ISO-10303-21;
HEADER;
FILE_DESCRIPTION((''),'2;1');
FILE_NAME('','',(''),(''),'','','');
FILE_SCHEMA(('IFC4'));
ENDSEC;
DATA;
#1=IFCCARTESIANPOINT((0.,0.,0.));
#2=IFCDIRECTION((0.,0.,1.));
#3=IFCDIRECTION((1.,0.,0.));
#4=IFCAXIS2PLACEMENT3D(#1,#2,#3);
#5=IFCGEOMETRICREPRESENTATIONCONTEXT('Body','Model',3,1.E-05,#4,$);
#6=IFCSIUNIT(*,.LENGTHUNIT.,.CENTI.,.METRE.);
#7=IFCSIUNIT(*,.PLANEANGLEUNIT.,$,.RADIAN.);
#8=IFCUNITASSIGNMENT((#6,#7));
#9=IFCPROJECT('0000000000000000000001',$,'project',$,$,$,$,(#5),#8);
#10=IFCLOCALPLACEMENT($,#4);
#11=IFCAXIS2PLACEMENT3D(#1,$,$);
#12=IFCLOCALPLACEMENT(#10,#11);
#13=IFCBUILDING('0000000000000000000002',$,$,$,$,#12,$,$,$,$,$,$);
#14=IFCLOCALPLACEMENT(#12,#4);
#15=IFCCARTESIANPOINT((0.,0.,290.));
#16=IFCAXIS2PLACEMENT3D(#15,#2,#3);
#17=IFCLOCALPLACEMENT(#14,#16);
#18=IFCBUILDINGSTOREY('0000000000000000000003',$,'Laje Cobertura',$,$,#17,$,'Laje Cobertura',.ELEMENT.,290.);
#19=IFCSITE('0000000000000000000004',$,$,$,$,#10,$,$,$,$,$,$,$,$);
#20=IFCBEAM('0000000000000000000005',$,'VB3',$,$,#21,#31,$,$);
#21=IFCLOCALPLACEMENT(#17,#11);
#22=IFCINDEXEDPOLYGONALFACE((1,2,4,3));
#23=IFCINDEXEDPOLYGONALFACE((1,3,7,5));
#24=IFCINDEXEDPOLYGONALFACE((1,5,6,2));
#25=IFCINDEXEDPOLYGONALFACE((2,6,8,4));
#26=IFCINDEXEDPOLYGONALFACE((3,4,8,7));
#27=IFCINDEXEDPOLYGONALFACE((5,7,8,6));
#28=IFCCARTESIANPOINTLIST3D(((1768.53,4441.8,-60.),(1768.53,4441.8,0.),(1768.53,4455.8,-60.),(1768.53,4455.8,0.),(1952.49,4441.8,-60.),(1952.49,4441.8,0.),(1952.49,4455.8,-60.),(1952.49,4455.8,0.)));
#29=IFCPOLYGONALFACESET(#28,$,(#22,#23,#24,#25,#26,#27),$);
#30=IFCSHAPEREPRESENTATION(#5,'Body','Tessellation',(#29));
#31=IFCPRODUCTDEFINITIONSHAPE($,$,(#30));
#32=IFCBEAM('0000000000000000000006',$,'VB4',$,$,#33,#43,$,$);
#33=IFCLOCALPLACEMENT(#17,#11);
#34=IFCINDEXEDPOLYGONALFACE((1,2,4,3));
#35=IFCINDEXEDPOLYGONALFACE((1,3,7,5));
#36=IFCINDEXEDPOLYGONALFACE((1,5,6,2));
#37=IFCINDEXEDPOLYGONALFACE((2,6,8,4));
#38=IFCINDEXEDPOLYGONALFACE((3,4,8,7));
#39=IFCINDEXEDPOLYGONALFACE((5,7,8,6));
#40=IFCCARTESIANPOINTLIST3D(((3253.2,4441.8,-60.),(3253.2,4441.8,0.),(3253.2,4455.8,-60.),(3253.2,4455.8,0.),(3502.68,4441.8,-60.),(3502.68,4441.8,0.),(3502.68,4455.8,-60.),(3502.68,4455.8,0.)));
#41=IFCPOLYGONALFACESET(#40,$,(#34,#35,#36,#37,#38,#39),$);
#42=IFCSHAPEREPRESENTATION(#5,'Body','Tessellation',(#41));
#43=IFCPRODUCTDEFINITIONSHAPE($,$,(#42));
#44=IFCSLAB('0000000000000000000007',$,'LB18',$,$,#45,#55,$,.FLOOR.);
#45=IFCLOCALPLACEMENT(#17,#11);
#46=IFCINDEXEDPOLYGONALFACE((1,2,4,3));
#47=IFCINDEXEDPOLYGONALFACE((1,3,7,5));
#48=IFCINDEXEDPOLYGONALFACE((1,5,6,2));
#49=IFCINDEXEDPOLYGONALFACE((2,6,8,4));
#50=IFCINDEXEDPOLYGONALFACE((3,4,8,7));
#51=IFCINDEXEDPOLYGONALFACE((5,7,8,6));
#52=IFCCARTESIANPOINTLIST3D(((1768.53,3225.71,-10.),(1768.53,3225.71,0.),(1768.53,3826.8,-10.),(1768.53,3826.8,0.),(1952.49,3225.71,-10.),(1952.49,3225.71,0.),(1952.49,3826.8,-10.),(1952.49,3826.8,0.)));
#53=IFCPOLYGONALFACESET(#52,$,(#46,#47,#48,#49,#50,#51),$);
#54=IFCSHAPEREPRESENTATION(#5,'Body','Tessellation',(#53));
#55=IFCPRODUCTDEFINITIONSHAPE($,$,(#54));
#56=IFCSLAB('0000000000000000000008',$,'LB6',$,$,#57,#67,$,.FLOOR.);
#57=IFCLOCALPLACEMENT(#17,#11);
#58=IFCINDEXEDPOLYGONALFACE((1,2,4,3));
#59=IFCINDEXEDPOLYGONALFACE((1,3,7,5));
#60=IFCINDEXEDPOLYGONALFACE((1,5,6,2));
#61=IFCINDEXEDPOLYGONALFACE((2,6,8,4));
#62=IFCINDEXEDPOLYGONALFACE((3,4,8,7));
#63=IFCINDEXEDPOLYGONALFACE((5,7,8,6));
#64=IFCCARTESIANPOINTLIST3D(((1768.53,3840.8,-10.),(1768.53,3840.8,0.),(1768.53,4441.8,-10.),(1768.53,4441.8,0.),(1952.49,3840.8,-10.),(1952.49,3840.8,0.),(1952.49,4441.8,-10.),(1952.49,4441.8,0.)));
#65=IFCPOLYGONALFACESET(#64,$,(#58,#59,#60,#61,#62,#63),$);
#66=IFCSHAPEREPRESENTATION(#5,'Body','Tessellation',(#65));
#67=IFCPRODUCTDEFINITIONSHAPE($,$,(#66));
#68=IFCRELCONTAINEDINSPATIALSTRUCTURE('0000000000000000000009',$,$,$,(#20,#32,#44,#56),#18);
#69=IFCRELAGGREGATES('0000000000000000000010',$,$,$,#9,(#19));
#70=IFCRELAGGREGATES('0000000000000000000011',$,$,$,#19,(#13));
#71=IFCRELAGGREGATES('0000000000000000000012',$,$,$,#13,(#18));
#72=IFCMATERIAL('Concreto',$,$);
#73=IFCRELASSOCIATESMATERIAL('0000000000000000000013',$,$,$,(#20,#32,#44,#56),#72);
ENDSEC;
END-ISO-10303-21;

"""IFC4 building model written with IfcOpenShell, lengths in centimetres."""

from ifc_helpers import new_model, si_unit, frame, origin, origin_with_axes, origin_2d_with_axis, place, context, project, spatial, polyline, rectangle, outline, extrude, material, element, save


model = new_model("IFC4")

# Units and contexts
model_context = context("Model", 3, precision=1e-05, world=origin_with_axes(), identifier="Body")
ifc_project = project(units=[si_unit("LENGTHUNIT", "METRE", prefix="CENTI"), si_unit("PLANEANGLEUNIT", "RADIAN")], contexts=[model_context])

# Site, building, storey
site_placement = place(None, origin_with_axes())
site = spatial("IfcSite", under=ifc_project, at=site_placement)
building_placement = place(site_placement, origin())
building = spatial("IfcBuilding", under=site, at=building_placement)
placement = place(building_placement, origin_with_axes())
storey_placement = place(placement, frame((0.0, 0.0, 290.0), z_axis=(0.0, 0.0, 1.0), x_axis=(1.0, 0.0, 0.0)))
storey = spatial("IfcBuildingStorey", under=building, at=storey_placement, Name="Laje Cobertura", LongName="Laje Cobertura", CompositionType="ELEMENT", Elevation=290.0)

# Shared definitions
ifc_material = material(Name="Concreto")

# Beams
beam_1_placement = place(storey_placement, frame((1860.51, 4448.8, 0.0), z_axis=(0.0, 0.0, 1.0), x_axis=(1.0, 0.0, 0.0)))
element("IfcBeam", 1, at=beam_1_placement, inside=storey, material=ifc_material, Name="VB3", context=model_context, shape_type="SolidModel", body=[
    extrude(rectangle(XDim=14.0, YDim=60.0, at=origin_2d_with_axis()), frame((-91.98, 0.0, -30.0), z_axis=(1.0, 0.0, 0.0), x_axis=(0.0, 1.0, 0.0)), (0.0, 0.0, 1.0), 183.96),
])
beam_2_placement = place(storey_placement, frame((3377.94, 4448.8, 0.0), z_axis=(0.0, 0.0, 1.0), x_axis=(1.0, 0.0, 0.0)))
element("IfcBeam", 2, at=beam_2_placement, inside=storey, material=ifc_material, Name="VB4", context=model_context, shape_type="SolidModel", body=[
    extrude(rectangle(XDim=14.0, YDim=60.0, at=origin_2d_with_axis()), frame((-124.74, 0.0, -30.0), z_axis=(1.0, 0.0, 0.0), x_axis=(0.0, 1.0, 0.0)), (0.0, 0.0, 1.0), 249.48),
])

# Slabs
slab_1_placement = place(storey_placement, frame((1860.51, 3526.26, 0.0), z_axis=(0.0, 0.0, 1.0), x_axis=(1.0, 0.0, 0.0)))
element("IfcSlab", 3, at=slab_1_placement, inside=storey, material=ifc_material, Name="LB18", PredefinedType="FLOOR", context=model_context, shape_type="SolidModel", body=[
    extrude(outline(polyline([(91.98, -300.55), (91.98, 300.55), (-91.98, 300.54), (-91.98, -300.54), (91.98, -300.55), (91.98, -300.55)])), frame((0.0, 0.0, -10.0), z_axis=(0.0, 0.0, 1.0), x_axis=(1.0, 0.0, 0.0)), (0.0, 0.0, 1.0), 10.0),
])
slab_2_placement = place(storey_placement, frame((1860.51, 4141.3, 0.0), z_axis=(0.0, 0.0, 1.0), x_axis=(1.0, 0.0, 0.0)))
element("IfcSlab", 4, at=slab_2_placement, inside=storey, material=ifc_material, Name="LB6", PredefinedType="FLOOR", context=model_context, shape_type="SolidModel", body=[
    extrude(outline(polyline([(91.98, -300.5), (91.98, 300.5), (-91.98, 300.5), (-91.98, -300.5), (91.98, -300.5), (91.98, -300.5)])), frame((0.0, 0.0, -10.0), z_axis=(0.0, 0.0, 1.0), x_axis=(1.0, 0.0, 0.0)), (0.0, 0.0, 1.0), 10.0),
])

save(model, "model.ifc")
